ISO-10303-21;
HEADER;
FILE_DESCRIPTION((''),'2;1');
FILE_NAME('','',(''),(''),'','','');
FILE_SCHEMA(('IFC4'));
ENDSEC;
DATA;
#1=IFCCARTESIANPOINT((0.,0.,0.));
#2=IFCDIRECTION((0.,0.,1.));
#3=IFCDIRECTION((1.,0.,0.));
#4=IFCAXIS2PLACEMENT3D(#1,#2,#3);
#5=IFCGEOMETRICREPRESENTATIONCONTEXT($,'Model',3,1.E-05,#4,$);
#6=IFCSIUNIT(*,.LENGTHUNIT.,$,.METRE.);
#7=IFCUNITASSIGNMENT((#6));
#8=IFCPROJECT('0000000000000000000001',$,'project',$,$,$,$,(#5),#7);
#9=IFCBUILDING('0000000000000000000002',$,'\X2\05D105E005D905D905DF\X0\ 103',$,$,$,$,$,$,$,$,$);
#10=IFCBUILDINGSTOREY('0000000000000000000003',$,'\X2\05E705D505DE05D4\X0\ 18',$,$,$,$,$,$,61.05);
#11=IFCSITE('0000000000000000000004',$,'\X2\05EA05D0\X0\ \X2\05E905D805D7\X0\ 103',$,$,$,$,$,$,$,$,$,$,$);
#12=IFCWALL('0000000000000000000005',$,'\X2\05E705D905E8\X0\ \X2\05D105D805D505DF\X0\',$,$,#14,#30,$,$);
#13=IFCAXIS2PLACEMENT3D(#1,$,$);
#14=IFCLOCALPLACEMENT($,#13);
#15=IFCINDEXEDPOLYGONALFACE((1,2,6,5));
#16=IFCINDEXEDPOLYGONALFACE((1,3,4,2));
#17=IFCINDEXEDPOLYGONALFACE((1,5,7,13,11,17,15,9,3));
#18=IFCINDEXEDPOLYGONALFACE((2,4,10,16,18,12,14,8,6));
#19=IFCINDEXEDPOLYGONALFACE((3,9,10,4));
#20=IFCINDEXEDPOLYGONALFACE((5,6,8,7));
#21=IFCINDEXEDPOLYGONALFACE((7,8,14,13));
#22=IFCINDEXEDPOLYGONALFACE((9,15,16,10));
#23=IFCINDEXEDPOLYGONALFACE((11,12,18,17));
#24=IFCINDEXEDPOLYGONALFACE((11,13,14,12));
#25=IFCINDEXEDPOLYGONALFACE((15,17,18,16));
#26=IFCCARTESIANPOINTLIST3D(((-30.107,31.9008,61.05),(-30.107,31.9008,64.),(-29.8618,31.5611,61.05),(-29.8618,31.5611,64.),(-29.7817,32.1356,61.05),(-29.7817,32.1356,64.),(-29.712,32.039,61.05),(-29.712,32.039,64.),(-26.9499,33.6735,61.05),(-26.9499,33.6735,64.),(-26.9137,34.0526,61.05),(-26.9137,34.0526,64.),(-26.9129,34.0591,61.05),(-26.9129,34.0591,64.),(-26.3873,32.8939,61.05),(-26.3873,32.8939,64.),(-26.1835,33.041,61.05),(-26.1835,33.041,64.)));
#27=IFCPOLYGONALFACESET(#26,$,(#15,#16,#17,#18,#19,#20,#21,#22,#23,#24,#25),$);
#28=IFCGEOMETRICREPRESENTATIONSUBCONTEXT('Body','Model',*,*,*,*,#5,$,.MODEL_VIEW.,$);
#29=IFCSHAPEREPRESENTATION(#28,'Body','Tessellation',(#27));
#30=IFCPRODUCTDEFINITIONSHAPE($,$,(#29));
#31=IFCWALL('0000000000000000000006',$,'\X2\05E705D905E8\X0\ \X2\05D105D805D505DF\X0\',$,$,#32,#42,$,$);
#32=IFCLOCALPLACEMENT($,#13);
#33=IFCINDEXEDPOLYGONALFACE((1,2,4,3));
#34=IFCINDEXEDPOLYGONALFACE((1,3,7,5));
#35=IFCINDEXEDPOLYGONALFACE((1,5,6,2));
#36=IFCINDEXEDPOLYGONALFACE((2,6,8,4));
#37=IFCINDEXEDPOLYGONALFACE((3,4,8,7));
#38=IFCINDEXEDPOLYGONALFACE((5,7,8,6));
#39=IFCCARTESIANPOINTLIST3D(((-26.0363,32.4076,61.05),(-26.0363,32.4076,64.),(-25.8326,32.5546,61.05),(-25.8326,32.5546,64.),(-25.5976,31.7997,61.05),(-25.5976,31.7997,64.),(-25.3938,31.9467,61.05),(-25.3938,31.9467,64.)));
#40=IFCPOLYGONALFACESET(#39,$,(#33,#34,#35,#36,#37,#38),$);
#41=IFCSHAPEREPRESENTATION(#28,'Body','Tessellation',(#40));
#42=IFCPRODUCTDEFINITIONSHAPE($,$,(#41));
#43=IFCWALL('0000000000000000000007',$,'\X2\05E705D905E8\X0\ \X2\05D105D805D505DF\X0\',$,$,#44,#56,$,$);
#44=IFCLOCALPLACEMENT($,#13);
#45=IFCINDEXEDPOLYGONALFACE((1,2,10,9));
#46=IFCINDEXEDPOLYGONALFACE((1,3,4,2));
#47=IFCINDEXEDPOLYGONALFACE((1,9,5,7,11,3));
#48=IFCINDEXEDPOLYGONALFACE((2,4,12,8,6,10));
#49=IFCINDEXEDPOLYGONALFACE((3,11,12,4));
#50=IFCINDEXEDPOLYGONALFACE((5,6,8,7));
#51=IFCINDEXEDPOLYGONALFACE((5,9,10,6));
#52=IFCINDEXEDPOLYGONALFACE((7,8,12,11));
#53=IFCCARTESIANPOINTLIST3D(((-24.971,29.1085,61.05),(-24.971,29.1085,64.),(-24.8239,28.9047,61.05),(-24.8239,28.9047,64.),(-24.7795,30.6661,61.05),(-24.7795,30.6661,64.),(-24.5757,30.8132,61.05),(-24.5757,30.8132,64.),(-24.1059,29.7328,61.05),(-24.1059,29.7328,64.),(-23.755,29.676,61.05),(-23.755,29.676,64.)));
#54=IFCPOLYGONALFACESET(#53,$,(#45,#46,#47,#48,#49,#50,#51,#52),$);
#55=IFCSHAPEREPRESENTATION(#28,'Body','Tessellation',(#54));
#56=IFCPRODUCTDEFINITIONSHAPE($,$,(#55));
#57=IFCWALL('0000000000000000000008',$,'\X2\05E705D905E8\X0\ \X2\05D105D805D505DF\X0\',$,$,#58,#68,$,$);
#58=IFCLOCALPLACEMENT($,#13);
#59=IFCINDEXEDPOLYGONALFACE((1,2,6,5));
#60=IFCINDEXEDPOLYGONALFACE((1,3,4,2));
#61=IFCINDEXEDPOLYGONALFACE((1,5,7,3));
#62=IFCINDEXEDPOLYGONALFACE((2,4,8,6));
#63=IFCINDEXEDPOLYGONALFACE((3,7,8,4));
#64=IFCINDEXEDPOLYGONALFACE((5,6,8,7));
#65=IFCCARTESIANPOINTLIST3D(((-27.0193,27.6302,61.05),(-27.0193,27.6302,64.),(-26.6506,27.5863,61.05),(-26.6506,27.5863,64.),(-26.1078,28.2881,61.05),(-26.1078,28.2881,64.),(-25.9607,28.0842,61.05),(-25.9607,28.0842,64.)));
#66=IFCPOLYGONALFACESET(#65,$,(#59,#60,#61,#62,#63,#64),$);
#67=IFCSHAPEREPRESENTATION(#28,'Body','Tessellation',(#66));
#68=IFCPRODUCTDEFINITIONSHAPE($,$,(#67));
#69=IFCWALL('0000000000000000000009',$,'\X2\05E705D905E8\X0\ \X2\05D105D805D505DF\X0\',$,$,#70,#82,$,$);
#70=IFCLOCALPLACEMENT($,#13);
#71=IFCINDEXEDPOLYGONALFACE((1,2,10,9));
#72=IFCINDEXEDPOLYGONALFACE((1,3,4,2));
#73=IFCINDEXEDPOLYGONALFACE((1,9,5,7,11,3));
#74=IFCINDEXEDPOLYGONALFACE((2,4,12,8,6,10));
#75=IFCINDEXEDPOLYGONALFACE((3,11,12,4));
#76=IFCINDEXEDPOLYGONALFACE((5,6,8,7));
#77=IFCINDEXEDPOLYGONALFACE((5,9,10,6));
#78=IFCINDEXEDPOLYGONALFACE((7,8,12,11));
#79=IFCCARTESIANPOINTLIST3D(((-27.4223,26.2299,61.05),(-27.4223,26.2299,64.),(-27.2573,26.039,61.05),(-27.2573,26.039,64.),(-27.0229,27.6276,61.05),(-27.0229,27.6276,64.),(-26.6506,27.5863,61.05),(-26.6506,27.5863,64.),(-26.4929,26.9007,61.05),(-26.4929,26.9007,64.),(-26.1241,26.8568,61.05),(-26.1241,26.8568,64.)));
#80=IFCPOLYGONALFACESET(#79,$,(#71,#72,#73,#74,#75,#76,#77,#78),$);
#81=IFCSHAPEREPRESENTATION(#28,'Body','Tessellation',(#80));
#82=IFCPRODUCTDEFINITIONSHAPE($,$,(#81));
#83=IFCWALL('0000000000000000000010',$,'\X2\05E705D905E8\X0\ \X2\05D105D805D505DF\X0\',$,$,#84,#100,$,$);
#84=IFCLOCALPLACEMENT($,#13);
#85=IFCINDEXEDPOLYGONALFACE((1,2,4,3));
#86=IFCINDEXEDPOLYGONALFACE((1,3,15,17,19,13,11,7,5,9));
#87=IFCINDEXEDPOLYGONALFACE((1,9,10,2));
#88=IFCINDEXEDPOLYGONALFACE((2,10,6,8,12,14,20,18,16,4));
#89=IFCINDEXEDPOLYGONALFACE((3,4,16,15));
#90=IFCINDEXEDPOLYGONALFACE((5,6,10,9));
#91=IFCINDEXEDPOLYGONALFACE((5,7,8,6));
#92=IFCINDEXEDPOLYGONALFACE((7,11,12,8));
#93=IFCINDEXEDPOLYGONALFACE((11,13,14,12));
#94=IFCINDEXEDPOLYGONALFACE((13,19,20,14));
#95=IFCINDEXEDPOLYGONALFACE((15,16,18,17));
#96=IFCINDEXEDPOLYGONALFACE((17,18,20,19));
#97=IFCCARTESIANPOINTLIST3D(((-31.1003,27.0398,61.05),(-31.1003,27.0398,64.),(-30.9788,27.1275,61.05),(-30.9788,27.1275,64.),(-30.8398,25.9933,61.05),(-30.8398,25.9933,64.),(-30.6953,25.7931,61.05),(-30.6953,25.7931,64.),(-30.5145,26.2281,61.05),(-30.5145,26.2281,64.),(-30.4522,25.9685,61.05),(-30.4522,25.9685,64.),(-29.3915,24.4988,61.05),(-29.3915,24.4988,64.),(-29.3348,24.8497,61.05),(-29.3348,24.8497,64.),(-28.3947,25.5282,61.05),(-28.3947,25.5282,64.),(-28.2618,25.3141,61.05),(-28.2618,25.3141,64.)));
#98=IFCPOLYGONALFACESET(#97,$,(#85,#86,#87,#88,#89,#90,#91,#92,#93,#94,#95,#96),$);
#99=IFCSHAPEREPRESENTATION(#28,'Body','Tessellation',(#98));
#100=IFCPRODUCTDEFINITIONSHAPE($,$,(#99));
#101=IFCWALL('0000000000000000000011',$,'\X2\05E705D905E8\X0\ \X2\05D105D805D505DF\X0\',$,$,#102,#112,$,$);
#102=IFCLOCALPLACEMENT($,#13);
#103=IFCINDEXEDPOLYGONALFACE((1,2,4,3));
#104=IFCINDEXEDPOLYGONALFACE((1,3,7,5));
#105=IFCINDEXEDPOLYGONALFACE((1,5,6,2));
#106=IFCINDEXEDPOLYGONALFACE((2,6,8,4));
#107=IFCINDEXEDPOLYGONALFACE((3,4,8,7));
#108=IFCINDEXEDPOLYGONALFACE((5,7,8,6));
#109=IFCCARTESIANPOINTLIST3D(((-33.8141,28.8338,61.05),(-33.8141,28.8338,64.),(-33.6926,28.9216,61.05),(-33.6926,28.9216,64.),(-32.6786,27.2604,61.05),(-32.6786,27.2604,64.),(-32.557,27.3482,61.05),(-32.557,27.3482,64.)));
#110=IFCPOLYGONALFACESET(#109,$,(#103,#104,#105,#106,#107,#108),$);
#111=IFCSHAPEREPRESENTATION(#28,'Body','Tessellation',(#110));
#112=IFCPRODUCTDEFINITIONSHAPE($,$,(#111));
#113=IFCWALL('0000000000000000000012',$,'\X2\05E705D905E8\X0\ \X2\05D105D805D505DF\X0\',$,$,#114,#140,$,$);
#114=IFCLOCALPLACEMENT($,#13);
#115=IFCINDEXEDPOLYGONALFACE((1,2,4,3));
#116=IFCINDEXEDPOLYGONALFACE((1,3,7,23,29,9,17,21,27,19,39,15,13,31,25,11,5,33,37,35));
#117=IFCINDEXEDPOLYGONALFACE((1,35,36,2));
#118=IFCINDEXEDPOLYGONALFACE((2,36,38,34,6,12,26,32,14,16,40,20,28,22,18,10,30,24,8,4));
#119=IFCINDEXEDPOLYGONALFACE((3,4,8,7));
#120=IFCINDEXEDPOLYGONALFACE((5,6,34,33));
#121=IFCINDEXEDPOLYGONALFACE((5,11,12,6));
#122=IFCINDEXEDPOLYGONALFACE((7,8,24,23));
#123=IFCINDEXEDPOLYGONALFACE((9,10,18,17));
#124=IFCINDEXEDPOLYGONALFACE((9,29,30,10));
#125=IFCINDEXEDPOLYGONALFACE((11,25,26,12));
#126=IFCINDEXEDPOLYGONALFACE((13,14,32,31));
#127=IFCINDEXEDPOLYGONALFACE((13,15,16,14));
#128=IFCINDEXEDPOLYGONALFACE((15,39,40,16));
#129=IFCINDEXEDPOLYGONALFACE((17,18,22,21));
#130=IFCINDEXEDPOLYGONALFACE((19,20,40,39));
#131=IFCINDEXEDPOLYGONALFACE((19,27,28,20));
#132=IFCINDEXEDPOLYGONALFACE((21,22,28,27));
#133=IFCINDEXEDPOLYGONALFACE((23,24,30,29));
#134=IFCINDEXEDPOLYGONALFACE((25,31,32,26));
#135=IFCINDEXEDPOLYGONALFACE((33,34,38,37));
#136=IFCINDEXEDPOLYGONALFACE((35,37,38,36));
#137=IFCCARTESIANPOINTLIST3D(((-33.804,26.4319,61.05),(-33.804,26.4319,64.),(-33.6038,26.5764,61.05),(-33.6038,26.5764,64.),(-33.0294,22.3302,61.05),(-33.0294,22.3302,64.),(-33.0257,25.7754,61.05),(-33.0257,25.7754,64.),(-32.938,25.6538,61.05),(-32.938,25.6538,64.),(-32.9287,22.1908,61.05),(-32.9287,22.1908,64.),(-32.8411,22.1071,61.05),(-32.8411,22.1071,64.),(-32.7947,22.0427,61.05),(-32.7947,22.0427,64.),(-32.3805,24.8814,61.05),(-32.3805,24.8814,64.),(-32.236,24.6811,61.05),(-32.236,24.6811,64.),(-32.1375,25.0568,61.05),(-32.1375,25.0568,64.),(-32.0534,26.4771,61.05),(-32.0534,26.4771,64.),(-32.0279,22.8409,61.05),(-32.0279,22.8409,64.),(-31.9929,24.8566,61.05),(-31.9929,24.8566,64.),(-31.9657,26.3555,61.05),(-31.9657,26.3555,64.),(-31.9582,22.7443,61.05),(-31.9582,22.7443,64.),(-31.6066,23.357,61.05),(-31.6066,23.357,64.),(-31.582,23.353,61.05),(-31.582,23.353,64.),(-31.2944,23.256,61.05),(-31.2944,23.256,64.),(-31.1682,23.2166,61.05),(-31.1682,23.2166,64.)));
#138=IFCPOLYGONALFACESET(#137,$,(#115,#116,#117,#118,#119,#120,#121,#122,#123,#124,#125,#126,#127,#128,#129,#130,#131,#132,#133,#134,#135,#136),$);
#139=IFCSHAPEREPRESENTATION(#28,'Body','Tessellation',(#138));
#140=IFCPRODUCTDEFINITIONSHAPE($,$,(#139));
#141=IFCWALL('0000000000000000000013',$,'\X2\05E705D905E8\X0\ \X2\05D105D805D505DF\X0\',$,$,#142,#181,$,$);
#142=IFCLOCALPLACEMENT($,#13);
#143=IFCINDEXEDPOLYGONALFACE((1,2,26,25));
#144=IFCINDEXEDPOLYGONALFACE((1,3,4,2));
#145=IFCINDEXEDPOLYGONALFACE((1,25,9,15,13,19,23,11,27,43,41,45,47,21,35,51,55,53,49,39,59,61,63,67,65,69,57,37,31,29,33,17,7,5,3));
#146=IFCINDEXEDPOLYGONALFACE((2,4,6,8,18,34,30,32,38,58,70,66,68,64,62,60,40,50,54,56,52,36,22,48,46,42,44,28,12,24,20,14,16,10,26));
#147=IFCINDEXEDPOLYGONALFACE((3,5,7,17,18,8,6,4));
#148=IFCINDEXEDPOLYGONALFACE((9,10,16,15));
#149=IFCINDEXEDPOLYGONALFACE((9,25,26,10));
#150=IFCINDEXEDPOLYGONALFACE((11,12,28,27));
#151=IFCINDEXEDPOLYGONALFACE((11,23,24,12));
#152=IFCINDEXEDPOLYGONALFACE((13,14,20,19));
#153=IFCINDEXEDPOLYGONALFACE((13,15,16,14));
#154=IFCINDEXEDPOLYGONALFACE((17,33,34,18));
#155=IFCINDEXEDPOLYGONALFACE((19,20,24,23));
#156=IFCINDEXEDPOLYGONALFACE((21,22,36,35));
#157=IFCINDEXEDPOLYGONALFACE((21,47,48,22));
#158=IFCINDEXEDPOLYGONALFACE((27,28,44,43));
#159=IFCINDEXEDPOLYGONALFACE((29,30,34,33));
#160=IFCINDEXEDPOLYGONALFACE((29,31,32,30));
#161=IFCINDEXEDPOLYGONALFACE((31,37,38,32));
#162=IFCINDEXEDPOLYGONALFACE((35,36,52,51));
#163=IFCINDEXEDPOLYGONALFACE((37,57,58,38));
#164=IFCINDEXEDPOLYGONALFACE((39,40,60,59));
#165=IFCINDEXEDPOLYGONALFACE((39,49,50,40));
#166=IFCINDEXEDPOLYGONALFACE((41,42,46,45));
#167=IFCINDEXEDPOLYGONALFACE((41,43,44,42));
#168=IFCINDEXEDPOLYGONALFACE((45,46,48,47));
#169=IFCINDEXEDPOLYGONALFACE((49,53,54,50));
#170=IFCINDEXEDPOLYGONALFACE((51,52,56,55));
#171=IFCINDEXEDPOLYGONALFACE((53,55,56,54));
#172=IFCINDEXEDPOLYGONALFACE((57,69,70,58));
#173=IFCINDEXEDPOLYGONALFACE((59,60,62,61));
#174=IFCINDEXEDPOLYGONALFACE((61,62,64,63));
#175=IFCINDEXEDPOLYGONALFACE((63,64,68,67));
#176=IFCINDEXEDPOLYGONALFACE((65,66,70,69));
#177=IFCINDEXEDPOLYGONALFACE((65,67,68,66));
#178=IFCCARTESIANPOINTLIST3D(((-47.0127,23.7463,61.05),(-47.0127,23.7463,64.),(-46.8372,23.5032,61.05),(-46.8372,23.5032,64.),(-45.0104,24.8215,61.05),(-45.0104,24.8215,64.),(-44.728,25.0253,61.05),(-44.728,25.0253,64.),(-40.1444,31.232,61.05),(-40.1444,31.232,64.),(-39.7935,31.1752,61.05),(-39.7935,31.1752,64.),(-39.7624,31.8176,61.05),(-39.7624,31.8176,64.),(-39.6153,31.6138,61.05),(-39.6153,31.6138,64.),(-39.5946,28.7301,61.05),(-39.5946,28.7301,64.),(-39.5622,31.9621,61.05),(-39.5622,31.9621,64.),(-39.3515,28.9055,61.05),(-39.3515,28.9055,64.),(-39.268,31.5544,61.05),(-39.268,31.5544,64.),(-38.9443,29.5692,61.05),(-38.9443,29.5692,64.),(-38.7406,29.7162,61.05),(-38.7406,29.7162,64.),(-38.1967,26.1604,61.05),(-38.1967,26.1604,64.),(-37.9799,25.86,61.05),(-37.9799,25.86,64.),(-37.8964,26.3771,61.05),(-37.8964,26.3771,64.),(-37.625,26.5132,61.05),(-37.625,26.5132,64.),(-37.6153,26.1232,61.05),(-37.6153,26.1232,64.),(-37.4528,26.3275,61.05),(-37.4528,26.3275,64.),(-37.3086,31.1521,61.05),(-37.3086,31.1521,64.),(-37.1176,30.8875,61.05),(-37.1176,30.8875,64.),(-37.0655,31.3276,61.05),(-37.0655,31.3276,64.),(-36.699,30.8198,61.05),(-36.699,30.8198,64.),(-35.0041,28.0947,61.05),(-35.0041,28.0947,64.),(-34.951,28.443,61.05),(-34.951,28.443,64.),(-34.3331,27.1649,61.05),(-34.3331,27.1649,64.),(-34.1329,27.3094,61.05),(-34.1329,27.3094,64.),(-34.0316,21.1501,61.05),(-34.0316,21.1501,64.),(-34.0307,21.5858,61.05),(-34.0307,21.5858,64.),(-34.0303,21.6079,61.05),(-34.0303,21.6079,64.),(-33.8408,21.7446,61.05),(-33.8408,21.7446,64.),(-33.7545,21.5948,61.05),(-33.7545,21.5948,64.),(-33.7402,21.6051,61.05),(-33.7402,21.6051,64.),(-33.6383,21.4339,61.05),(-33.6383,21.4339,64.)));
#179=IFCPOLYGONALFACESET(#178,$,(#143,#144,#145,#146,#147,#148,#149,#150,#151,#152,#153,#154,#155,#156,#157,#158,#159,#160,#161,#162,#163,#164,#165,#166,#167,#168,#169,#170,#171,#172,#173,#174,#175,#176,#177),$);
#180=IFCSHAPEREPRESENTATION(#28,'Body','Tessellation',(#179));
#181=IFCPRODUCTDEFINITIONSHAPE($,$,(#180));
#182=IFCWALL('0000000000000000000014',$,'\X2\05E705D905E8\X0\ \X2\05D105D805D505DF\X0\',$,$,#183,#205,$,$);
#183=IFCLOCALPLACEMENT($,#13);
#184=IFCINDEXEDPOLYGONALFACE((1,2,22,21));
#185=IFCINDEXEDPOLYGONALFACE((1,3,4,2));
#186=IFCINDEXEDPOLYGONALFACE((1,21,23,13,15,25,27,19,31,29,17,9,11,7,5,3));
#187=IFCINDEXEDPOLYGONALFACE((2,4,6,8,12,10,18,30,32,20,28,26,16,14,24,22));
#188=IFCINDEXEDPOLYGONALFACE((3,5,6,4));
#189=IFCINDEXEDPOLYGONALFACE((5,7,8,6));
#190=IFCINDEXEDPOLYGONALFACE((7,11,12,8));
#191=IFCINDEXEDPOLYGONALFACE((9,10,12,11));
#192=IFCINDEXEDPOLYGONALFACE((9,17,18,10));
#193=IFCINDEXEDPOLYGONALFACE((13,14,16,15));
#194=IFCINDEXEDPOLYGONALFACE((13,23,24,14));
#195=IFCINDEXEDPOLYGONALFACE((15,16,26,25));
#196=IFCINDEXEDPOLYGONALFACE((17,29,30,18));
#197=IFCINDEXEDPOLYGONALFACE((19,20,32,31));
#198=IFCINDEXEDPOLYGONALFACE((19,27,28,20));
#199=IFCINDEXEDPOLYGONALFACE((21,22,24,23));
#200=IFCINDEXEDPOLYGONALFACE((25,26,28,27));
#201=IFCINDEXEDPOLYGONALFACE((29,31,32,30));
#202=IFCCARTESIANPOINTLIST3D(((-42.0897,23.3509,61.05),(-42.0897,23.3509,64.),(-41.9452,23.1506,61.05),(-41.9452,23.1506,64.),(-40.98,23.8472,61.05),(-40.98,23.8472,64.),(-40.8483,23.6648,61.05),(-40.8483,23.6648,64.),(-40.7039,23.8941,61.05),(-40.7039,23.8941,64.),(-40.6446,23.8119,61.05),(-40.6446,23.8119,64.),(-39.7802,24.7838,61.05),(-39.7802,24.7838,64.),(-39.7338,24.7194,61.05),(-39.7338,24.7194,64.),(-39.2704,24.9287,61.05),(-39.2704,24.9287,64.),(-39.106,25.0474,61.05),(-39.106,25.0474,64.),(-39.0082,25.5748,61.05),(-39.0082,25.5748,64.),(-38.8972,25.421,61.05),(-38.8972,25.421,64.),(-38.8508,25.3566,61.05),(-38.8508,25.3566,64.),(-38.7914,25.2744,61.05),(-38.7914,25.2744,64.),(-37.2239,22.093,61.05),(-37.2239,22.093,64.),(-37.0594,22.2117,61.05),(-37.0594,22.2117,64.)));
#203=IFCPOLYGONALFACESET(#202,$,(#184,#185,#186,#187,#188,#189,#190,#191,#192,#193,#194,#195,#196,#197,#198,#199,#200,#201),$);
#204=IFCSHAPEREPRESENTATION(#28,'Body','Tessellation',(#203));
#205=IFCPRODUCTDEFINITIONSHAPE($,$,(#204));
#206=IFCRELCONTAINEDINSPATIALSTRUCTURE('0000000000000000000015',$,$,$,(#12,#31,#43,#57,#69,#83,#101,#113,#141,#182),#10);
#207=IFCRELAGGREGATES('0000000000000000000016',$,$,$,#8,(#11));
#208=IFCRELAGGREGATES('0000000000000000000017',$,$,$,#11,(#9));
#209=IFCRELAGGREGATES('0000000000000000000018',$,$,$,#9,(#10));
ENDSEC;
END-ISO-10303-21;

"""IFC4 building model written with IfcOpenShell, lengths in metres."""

from ifc_helpers import new_model, si_unit, frame, origin_with_axes, context, subcontext, project, spatial, polyline, outline, extrude, element, save


model = new_model("IFC4")

# Units and contexts
model_context = context("Model", 3, precision=1e-05, world=origin_with_axes())
body_context = subcontext(model_context, "Body", "Model", "MODEL_VIEW")
ifc_project = project(units=[si_unit("LENGTHUNIT", "METRE")], contexts=[model_context])

# Site, building, storey
site = spatial("IfcSite", under=ifc_project, Name="תא שטח 103")
building = spatial("IfcBuilding", under=site, Name="בניין 103")
storey = spatial("IfcBuildingStorey", under=building, Name="קומה 18", Elevation=61.05)

# Walls
element("IfcWall", 1, inside=storey, Name="קיר בטון", context=body_context, shape_type="SweptSolid", body=[
    extrude(outline(polyline([(-26.9499, 33.6735), (-29.8618, 31.5611), (-30.107, 31.9008), (-29.7817, 32.1356), (-29.712, 32.039), (-26.9129, 34.0591), (-26.9203, 33.994), (-26.9139, 34.0529), (-26.1835, 33.041), (-26.3873, 32.8939), (-26.9499, 33.6735)])), frame((0.0, 0.0, 61.05)), (0.0, 0.0, 1.0), 2.95),
])
element("IfcWall", 2, inside=storey, Name="קיר בטון", context=body_context, shape_type="SweptSolid", body=[
    extrude(outline(polyline([(-25.8326, 32.5546), (-25.3938, 31.9467), (-25.5976, 31.7997), (-26.0363, 32.4076), (-25.8326, 32.5546)])), frame((0.0, 0.0, 61.05)), (0.0, 0.0, 1.0), 2.95),
])
element("IfcWall", 3, inside=storey, Name="קיר בטון", context=body_context, shape_type="SweptSolid", body=[
    extrude(outline(polyline([(-24.8239, 28.9047), (-24.971, 29.1085), (-24.1059, 29.7328), (-24.7795, 30.6661), (-24.5757, 30.8132), (-23.755, 29.676), (-24.8239, 28.9047)])), frame((0.0, 0.0, 61.05)), (0.0, 0.0, 1.0), 2.95),
])
element("IfcWall", 4, inside=storey, Name="קיר בטון", context=body_context, shape_type="SweptSolid", body=[
    extrude(outline(polyline([(-26.6506, 27.5863), (-27.0193, 27.6302), (-26.1078, 28.2881), (-25.9607, 28.0842), (-26.6506, 27.5863)])), frame((0.0, 0.0, 61.05)), (0.0, 0.0, 1.0), 2.95),
])
element("IfcWall", 5, inside=storey, Name="קיר בטון", context=body_context, shape_type="SweptSolid", body=[
    extrude(outline(polyline([(-27.2573, 26.039), (-27.4223, 26.2299), (-26.4929, 26.9007), (-27.0229, 27.6276), (-26.6506, 27.5863), (-26.1241, 26.8568), (-27.2573, 26.039)])), frame((0.0, 0.0, 61.05)), (0.0, 0.0, 1.0), 2.95),
])
element("IfcWall", 6, inside=storey, Name="קיר בטון", context=body_context, shape_type="SweptSolid", body=[
    extrude(outline(polyline([(-29.3915, 24.4988), (-30.4522, 25.9685), (-30.6953, 25.7931), (-30.8398, 25.9933), (-30.5145, 26.2281), (-31.1003, 27.0398), (-30.9788, 27.1275), (-29.3348, 24.8497), (-28.3947, 25.5282), (-28.2618, 25.3141), (-29.3915, 24.4988)])), frame((0.0, 0.0, 61.05)), (0.0, 0.0, 1.0), 2.95),
])
element("IfcWall", 7, inside=storey, Name="קיר בטון", context=body_context, shape_type="SweptSolid", body=[
    extrude(outline(polyline([(-32.6786, 27.2604), (-33.8141, 28.8338), (-33.6926, 28.9216), (-32.557, 27.3482), (-32.6786, 27.2604)])), frame((0.0, 0.0, 61.05)), (0.0, 0.0, 1.0), 2.95),
])
element("IfcWall", 8, inside=storey, Name="קיר בטון", context=body_context, shape_type="SweptSolid", body=[
    extrude(outline(polyline([(-32.236, 24.6811), (-31.1682, 23.2166), (-32.7947, 22.0427), (-32.8411, 22.1071), (-31.9582, 22.7443), (-32.0279, 22.8409), (-32.9287, 22.1908), (-33.0294, 22.3302), (-31.6066, 23.357), (-31.2944, 23.256), (-31.582, 23.353), (-33.804, 26.4319), (-33.6038, 26.5764), (-33.0257, 25.7754), (-32.0534, 26.4771), (-31.9657, 26.3555), (-32.938, 25.6538), (-32.3805, 24.8814), (-32.1375, 25.0568), (-31.9929, 24.8566), (-32.236, 24.6811)])), frame((0.0, 0.0, 61.05)), (0.0, 0.0, 1.0), 2.95),
])
element("IfcWall", 9, inside=storey, Name="קיר בטון", context=body_context, shape_type="SweptSolid", body=[
    extrude(outline(polyline([(-37.4528, 26.3275), (-34.0307, 21.5858), (-34.0303, 21.6079), (-33.8408, 21.7446), (-33.7402, 21.6051), (-33.7545, 21.5948), (-33.6383, 21.4339), (-34.0316, 21.1501), (-37.6153, 26.1232), (-37.9799, 25.86), (-38.1967, 26.1604), (-37.8964, 26.3771), (-39.5946, 28.7301), (-44.728, 25.0253), (-45.0104, 24.8215), (-46.8372, 23.5032), (-47.0127, 23.7463), (-38.9443, 29.5692), (-40.1444, 31.232), (-39.6153, 31.6138), (-39.7624, 31.8176), (-39.5622, 31.9621), (-39.268, 31.5544), (-39.7935, 31.1752), (-38.7406, 29.7162), (-37.1176, 30.8875), (-37.3086, 31.1521), (-37.0655, 31.3276), (-36.699, 30.8198), (-39.3515, 28.9055), (-37.625, 26.5132), (-34.951, 28.443), (-34.1329, 27.3094), (-34.3331, 27.1649), (-35.0041, 28.0947), (-37.4528, 26.3275)])), frame((0.0, 0.0, 61.05)), (0.0, 0.0, 1.0), 2.95),
])
element("IfcWall", 10, inside=storey, Name="קיר בטון", context=body_context, shape_type="SweptSolid", body=[
    extrude(outline(polyline([(-37.2239, 22.093), (-39.2704, 24.9287), (-40.7039, 23.8941), (-40.6446, 23.8119), (-40.8483, 23.6648), (-40.98, 23.8472), (-41.9452, 23.1506), (-42.0897, 23.3509), (-39.0082, 25.5748), (-38.8972, 25.421), (-39.7802, 24.7838), (-39.7338, 24.7194), (-38.8508, 25.3566), (-38.7914, 25.2744), (-39.106, 25.0474), (-37.0594, 22.2117), (-37.2239, 22.093)])), frame((0.0, 0.0, 61.05)), (0.0, 0.0, 1.0), 2.95),
])

save(model, "model.ifc")
